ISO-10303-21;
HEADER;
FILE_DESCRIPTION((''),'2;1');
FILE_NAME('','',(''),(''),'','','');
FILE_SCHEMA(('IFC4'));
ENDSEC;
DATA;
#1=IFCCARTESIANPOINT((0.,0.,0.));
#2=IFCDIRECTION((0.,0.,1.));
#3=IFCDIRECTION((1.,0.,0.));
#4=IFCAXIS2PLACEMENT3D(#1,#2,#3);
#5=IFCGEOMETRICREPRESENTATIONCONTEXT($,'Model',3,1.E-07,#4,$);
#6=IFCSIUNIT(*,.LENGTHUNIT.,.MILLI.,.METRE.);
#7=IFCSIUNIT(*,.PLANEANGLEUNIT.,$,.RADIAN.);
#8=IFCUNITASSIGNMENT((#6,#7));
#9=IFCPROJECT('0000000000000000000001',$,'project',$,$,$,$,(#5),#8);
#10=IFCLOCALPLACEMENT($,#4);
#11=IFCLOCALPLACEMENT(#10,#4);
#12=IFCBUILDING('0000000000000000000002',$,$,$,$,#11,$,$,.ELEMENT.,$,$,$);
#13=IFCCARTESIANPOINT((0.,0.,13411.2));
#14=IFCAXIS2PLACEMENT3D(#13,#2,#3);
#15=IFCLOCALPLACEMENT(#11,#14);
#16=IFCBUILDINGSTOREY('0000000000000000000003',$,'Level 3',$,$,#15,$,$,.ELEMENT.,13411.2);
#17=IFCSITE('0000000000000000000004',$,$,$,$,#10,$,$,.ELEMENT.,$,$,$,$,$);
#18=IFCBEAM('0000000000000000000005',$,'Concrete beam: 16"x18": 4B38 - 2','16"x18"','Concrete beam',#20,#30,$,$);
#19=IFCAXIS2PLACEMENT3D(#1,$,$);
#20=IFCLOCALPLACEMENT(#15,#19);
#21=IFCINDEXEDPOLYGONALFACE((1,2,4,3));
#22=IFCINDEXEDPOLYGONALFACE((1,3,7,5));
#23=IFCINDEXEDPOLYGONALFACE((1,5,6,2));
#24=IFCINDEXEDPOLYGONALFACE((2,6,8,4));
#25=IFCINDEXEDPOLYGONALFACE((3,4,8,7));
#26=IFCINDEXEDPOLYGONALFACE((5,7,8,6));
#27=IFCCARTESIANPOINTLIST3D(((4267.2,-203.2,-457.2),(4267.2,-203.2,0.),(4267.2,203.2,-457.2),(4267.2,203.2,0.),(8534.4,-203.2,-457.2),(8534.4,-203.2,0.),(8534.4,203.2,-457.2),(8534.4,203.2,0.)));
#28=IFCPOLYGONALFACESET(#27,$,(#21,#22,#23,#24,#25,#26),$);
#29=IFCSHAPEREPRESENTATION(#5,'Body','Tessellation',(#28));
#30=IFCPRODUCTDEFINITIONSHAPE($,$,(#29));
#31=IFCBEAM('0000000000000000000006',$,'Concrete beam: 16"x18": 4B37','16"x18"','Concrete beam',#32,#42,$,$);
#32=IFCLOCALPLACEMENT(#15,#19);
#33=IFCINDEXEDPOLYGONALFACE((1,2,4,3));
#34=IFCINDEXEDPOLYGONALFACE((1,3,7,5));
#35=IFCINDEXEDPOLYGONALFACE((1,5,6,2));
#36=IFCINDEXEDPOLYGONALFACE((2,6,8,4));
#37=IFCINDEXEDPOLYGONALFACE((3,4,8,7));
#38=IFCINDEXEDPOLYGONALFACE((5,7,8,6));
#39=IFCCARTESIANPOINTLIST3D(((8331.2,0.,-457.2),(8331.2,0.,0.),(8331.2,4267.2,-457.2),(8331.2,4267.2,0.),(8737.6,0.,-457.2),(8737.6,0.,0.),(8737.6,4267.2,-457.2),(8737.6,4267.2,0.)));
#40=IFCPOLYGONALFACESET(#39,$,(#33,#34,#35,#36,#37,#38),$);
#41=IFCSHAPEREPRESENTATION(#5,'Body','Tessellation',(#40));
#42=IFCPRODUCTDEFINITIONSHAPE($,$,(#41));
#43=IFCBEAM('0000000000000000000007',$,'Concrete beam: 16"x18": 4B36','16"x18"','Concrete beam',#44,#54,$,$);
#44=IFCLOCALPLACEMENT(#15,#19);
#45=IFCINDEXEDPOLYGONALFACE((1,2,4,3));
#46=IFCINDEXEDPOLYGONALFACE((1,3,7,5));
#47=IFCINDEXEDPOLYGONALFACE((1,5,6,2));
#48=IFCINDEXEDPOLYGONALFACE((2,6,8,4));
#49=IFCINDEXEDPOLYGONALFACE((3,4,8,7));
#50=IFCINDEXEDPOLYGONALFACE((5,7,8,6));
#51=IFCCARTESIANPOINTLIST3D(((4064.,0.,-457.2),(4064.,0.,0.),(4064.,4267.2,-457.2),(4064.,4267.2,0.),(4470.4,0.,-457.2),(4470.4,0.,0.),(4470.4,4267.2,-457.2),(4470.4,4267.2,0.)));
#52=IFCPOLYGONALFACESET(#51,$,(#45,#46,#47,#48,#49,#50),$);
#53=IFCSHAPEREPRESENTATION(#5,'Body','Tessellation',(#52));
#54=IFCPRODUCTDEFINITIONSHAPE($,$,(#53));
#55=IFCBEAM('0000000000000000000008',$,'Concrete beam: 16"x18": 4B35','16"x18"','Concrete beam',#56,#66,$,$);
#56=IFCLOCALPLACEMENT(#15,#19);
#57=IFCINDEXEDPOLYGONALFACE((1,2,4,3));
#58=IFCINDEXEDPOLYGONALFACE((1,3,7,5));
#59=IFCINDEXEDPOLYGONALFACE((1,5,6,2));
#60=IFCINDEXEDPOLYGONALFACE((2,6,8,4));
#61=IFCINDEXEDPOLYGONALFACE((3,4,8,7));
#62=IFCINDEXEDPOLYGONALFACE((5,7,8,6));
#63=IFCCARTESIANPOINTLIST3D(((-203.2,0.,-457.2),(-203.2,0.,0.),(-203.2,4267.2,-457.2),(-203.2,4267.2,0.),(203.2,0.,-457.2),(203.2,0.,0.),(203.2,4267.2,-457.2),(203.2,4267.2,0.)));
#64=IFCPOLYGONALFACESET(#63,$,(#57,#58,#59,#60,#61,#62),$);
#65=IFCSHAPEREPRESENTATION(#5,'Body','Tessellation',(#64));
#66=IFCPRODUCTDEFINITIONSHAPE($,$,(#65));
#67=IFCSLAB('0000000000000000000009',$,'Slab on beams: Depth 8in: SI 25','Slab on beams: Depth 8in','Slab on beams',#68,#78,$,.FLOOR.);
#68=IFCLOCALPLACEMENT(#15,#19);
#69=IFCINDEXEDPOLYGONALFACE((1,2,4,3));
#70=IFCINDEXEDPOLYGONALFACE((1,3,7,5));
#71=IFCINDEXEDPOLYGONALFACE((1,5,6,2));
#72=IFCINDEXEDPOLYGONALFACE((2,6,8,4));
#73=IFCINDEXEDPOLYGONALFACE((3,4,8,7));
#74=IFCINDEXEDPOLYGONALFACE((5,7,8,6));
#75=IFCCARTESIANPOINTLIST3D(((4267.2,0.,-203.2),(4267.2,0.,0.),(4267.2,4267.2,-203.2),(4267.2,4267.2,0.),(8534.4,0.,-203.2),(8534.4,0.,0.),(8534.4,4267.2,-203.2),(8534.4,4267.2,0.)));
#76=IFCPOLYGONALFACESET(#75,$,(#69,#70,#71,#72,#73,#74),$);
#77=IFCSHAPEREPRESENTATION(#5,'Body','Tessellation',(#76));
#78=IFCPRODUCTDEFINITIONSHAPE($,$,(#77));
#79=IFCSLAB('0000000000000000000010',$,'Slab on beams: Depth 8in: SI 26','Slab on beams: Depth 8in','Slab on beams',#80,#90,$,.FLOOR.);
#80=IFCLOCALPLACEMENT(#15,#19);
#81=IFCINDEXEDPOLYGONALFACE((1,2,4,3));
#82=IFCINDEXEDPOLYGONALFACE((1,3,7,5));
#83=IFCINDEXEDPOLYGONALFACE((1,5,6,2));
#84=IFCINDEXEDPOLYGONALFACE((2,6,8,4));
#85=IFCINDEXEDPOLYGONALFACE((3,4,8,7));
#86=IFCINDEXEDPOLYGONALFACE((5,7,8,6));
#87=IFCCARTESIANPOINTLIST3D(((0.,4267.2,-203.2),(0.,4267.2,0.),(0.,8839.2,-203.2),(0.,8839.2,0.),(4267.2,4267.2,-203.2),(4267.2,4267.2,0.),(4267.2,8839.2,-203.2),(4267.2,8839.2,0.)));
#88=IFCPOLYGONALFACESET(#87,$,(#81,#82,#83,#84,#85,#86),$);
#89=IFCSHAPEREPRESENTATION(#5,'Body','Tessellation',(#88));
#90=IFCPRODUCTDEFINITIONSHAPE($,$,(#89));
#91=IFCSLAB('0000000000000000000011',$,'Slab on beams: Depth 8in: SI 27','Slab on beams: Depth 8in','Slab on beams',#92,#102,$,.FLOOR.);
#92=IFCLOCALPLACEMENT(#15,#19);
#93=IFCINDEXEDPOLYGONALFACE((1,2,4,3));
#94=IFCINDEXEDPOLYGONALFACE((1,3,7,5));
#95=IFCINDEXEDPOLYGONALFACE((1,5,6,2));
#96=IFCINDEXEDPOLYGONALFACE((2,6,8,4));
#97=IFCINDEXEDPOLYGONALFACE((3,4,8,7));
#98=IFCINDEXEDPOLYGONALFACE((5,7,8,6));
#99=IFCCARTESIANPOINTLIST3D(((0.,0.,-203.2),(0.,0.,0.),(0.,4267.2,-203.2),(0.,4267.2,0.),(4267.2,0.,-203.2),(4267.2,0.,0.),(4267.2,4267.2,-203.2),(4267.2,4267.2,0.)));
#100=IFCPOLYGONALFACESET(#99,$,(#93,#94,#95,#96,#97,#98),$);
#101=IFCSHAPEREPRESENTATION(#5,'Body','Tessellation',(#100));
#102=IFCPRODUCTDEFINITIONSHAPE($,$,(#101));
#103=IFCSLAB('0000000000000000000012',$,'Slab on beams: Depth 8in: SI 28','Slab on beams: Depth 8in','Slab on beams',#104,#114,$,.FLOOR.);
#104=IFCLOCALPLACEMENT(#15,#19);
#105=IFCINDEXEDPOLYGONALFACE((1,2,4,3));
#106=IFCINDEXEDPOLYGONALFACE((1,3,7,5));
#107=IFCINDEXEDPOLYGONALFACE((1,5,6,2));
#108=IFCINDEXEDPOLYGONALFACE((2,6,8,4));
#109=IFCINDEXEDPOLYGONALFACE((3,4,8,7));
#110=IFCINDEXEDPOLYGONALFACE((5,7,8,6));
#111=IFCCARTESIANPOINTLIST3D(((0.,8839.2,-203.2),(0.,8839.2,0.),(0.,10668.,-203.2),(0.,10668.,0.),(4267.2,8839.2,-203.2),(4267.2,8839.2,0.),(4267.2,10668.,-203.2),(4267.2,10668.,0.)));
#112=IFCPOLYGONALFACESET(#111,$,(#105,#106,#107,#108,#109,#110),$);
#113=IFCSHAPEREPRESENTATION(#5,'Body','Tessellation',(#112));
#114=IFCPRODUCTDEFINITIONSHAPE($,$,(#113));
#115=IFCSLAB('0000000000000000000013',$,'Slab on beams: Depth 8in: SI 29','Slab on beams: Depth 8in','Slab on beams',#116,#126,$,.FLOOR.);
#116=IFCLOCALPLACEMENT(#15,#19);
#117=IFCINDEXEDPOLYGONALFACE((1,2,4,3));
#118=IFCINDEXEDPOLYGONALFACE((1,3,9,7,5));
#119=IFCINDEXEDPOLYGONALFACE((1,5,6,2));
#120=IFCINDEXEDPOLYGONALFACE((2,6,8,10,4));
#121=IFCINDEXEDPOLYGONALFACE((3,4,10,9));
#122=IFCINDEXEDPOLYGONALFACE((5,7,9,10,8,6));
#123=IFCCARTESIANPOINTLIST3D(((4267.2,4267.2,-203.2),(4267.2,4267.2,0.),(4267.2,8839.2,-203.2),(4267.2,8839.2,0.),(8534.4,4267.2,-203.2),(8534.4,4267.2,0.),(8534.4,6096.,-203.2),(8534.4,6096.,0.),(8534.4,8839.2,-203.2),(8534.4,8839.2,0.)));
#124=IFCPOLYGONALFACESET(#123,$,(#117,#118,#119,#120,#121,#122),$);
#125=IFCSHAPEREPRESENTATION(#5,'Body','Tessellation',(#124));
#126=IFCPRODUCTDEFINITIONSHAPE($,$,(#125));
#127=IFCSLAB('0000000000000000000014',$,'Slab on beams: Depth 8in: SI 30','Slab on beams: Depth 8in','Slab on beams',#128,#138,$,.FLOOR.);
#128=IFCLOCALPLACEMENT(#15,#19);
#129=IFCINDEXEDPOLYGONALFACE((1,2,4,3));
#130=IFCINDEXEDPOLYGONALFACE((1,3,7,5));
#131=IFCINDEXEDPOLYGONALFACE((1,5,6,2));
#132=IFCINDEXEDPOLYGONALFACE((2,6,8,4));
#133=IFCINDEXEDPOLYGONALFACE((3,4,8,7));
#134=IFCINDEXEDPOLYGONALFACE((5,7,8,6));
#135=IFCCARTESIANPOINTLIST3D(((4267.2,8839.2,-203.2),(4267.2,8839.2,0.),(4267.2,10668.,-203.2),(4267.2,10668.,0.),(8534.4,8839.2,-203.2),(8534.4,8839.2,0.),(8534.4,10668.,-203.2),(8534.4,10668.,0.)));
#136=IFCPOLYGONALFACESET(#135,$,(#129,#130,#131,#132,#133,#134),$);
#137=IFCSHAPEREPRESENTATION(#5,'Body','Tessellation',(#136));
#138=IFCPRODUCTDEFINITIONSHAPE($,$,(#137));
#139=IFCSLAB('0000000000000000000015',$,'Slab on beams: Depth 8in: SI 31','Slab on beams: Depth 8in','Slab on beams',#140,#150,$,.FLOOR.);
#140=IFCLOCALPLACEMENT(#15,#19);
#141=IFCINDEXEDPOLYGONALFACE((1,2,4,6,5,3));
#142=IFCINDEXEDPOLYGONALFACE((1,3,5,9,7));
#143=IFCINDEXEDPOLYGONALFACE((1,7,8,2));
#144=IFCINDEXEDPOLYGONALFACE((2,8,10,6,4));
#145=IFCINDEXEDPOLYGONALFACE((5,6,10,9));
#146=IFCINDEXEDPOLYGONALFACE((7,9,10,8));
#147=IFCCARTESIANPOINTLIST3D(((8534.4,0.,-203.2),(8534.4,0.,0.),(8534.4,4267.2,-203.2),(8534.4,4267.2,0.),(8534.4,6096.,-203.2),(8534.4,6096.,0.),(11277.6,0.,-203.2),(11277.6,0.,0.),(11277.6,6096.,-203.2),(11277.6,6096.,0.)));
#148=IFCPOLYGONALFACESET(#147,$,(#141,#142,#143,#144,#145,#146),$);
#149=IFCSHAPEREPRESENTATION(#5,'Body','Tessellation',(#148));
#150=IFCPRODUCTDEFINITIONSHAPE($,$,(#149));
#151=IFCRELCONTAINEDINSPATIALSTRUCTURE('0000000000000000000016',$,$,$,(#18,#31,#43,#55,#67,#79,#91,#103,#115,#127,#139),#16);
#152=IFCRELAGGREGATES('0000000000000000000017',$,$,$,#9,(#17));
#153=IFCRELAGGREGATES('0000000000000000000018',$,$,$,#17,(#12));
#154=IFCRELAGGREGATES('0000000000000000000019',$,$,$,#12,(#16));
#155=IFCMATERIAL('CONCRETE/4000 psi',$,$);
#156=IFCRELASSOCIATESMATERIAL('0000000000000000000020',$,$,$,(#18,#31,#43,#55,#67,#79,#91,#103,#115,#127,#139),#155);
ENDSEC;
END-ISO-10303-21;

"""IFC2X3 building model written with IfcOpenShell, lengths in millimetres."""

from ifc_helpers import new_model, si_unit, frame, origin_with_axes, origin_2d_with_axis, place, context, project, spatial, polyline, segment, composite_curve, rectangle, outline, extrude, material, element, save


model = new_model("IFC2X3")

# Units and contexts
model_context = context("Model", 3, precision=1e-07, world=origin_with_axes())
ifc_project = project(units=[si_unit("LENGTHUNIT", "METRE", prefix="MILLI"), si_unit("PLANEANGLEUNIT", "RADIAN")], contexts=[model_context])

# Site, building, storey
site_placement = place(None, origin_with_axes())
site = spatial("IfcSite", under=ifc_project, at=site_placement, CompositionType="ELEMENT")
building_placement = place(site_placement, origin_with_axes())
building = spatial("IfcBuilding", under=site, at=building_placement, CompositionType="ELEMENT")
storey_placement = place(building_placement, frame((0.0, 0.0, 13411.2), z_axis=(0.0, 0.0, 1.0), x_axis=(1.0, 0.0, 0.0)))
storey = spatial("IfcBuildingStorey", under=building, at=storey_placement, Name="Level 3", CompositionType="ELEMENT", Elevation=13411.2)

# Beams
ifc_material = material(Name="CONCRETE/4000 psi")
for number, where, z_axis, x_axis, name in (
    (1, (4267.2, 0.0, 13411.2), (0.0, 0.0, 1.0), (1.0, 0.0, 0.0), "Concrete beam: 16\"x18\": 4B38 - 2"),
    (2, (8534.4, 0.0, 13411.2), (0.0, 0.0, 1.0), (0.0, 1.0, 0.0), "Concrete beam: 16\"x18\": 4B37"),
    (3, (4267.2, 0.0, 13411.2), (0.0, 0.0, 1.0), (0.0, 1.0, 0.0), "Concrete beam: 16\"x18\": 4B36"),
    (4, (0.0, 0.0, 13411.2), (0.0, 0.0, 1.0), (0.0, 1.0, 0.0), "Concrete beam: 16\"x18\": 4B35"),
):
    element("IfcBeam", number, at=place(building_placement, frame(where, z_axis=z_axis, x_axis=x_axis)), inside=storey, material=ifc_material, Name=name, Description="16\"x18\"", ObjectType="Concrete beam", context=model_context, shape_type="SweptSolid", body=[
        extrude(rectangle(XDim=406.4, YDim=457.2, at=origin_2d_with_axis()), frame((4267.2, 0.0, -228.6), z_axis=(-1.0, 0.0, 0.0), x_axis=(0.0, -1.0, 0.0)), (0.0, 0.0, 1.0), 4267.2),
    ])

# Slabs
slab_1_placement = place(building_placement, frame((0.0, 0.0, 13411.2), z_axis=(0.0, 0.0, 1.0), x_axis=(1.0, 0.0, 0.0)))
element("IfcSlab", 5, at=slab_1_placement, inside=storey, material=ifc_material, Name="Slab on beams: Depth 8in: SI 25", Description="Slab on beams: Depth 8in", ObjectType="Slab on beams", PredefinedType="FLOOR", context=model_context, shape_type="SweptSolid", body=[
    extrude(outline(composite_curve([segment(polyline([(4267.2, 4267.2), (4267.2, 0.0)]), True, "CONTINUOUS"), segment(polyline([(4267.2, 0.0), (8534.4, 0.0)]), True, "CONTINUOUS"), segment(polyline([(8534.4, 0.0), (8534.4, 4267.2)]), True, "CONTINUOUS"), segment(polyline([(8534.4, 4267.2), (4267.2, 4267.2)]), True, "CONTINUOUS")], self_intersect=False)), frame((0.0, 0.0, -203.2), z_axis=(0.0, 0.0, 1.0), x_axis=(1.0, 0.0, 0.0)), (0.0, 0.0, 1.0), 203.2),
])
slab_2_placement = place(building_placement, frame((0.0, 0.0, 13411.2), z_axis=(0.0, 0.0, 1.0), x_axis=(1.0, 0.0, 0.0)))
element("IfcSlab", 6, at=slab_2_placement, inside=storey, material=ifc_material, Name="Slab on beams: Depth 8in: SI 26", Description="Slab on beams: Depth 8in", ObjectType="Slab on beams", PredefinedType="FLOOR", context=model_context, shape_type="SweptSolid", body=[
    extrude(outline(composite_curve([segment(polyline([(0.0, 8839.2), (0.0, 4267.2)]), True, "CONTINUOUS"), segment(polyline([(0.0, 4267.2), (4267.2, 4267.2)]), True, "CONTINUOUS"), segment(polyline([(4267.2, 4267.2), (4267.2, 8839.2)]), True, "CONTINUOUS"), segment(polyline([(4267.2, 8839.2), (0.0, 8839.2)]), True, "CONTINUOUS")], self_intersect=False)), frame((0.0, 0.0, -203.2), z_axis=(0.0, 0.0, 1.0), x_axis=(1.0, 0.0, 0.0)), (0.0, 0.0, 1.0), 203.2),
])
slab_3_placement = place(building_placement, frame((0.0, 0.0, 13411.2), z_axis=(0.0, 0.0, 1.0), x_axis=(1.0, 0.0, 0.0)))
element("IfcSlab", 7, at=slab_3_placement, inside=storey, material=ifc_material, Name="Slab on beams: Depth 8in: SI 27", Description="Slab on beams: Depth 8in", ObjectType="Slab on beams", PredefinedType="FLOOR", context=model_context, shape_type="SweptSolid", body=[
    extrude(outline(composite_curve([segment(polyline([(0.0, 4267.2), (0.0, 0.0)]), True, "CONTINUOUS"), segment(polyline([(0.0, 0.0), (4267.2, 0.0)]), True, "CONTINUOUS"), segment(polyline([(4267.2, 0.0), (4267.2, 4267.2)]), True, "CONTINUOUS"), segment(polyline([(4267.2, 4267.2), (0.0, 4267.2)]), True, "CONTINUOUS")], self_intersect=False)), frame((0.0, 0.0, -203.2), z_axis=(0.0, 0.0, 1.0), x_axis=(1.0, 0.0, 0.0)), (0.0, 0.0, 1.0), 203.2),
])
slab_4_placement = place(building_placement, frame((0.0, 0.0, 13411.2), z_axis=(0.0, 0.0, 1.0), x_axis=(1.0, 0.0, 0.0)))
element("IfcSlab", 8, at=slab_4_placement, inside=storey, material=ifc_material, Name="Slab on beams: Depth 8in: SI 28", Description="Slab on beams: Depth 8in", ObjectType="Slab on beams", PredefinedType="FLOOR", context=model_context, shape_type="SweptSolid", body=[
    extrude(outline(composite_curve([segment(polyline([(0.0, 10668.0), (0.0, 8839.2)]), True, "CONTINUOUS"), segment(polyline([(0.0, 8839.2), (4267.2, 8839.2)]), True, "CONTINUOUS"), segment(polyline([(4267.2, 8839.2), (4267.2, 10668.0)]), True, "CONTINUOUS"), segment(polyline([(4267.2, 10668.0), (0.0, 10668.0)]), True, "CONTINUOUS")], self_intersect=False)), frame((0.0, 0.0, -203.2), z_axis=(0.0, 0.0, 1.0), x_axis=(1.0, 0.0, 0.0)), (0.0, 0.0, 1.0), 203.2),
])
slab_5_placement = place(building_placement, frame((0.0, 0.0, 13411.2), z_axis=(0.0, 0.0, 1.0), x_axis=(1.0, 0.0, 0.0)))
element("IfcSlab", 9, at=slab_5_placement, inside=storey, material=ifc_material, Name="Slab on beams: Depth 8in: SI 29", Description="Slab on beams: Depth 8in", ObjectType="Slab on beams", PredefinedType="FLOOR", context=model_context, shape_type="SweptSolid", body=[
    extrude(outline(composite_curve([segment(polyline([(4267.2, 8839.2), (4267.2, 4267.2)]), True, "CONTINUOUS"), segment(polyline([(4267.2, 4267.2), (8534.4, 4267.2)]), True, "CONTINUOUS"), segment(polyline([(8534.4, 4267.2), (8534.4, 6096.0)]), True, "CONTINUOUS"), segment(polyline([(8534.4, 6096.0), (8534.4, 8839.2)]), True, "CONTINUOUS"), segment(polyline([(8534.4, 8839.2), (4267.2, 8839.2)]), True, "CONTINUOUS")], self_intersect=False)), frame((0.0, 0.0, -203.2), z_axis=(0.0, 0.0, 1.0), x_axis=(1.0, 0.0, 0.0)), (0.0, 0.0, 1.0), 203.2),
])
slab_6_placement = place(building_placement, frame((0.0, 0.0, 13411.2), z_axis=(0.0, 0.0, 1.0), x_axis=(1.0, 0.0, 0.0)))
element("IfcSlab", 10, at=slab_6_placement, inside=storey, material=ifc_material, Name="Slab on beams: Depth 8in: SI 30", Description="Slab on beams: Depth 8in", ObjectType="Slab on beams", PredefinedType="FLOOR", context=model_context, shape_type="SweptSolid", body=[
    extrude(outline(composite_curve([segment(polyline([(4267.2, 10668.0), (4267.2, 8839.2)]), True, "CONTINUOUS"), segment(polyline([(4267.2, 8839.2), (8534.4, 8839.2)]), True, "CONTINUOUS"), segment(polyline([(8534.4, 8839.2), (8534.4, 10668.0)]), True, "CONTINUOUS"), segment(polyline([(8534.4, 10668.0), (4267.2, 10668.0)]), True, "CONTINUOUS")], self_intersect=False)), frame((0.0, 0.0, -203.2), z_axis=(0.0, 0.0, 1.0), x_axis=(1.0, 0.0, 0.0)), (0.0, 0.0, 1.0), 203.2),
])
slab_7_placement = place(building_placement, frame((0.0, 0.0, 13411.2), z_axis=(0.0, 0.0, 1.0), x_axis=(1.0, 0.0, 0.0)))
element("IfcSlab", 11, at=slab_7_placement, inside=storey, material=ifc_material, Name="Slab on beams: Depth 8in: SI 31", Description="Slab on beams: Depth 8in", ObjectType="Slab on beams", PredefinedType="FLOOR", context=model_context, shape_type="SweptSolid", body=[
    extrude(outline(composite_curve([segment(polyline([(8534.4, 6096.0), (8534.4, 4267.2)]), True, "CONTINUOUS"), segment(polyline([(8534.4, 4267.2), (8534.4, 0.0)]), True, "CONTINUOUS"), segment(polyline([(8534.4, 0.0), (11277.6, 0.0)]), True, "CONTINUOUS"), segment(polyline([(11277.6, 0.0), (11277.6, 6096.0)]), True, "CONTINUOUS"), segment(polyline([(11277.6, 6096.0), (8534.4, 6096.0)]), True, "CONTINUOUS")], self_intersect=False)), frame((0.0, 0.0, -203.2), z_axis=(0.0, 0.0, 1.0), x_axis=(1.0, 0.0, 0.0)), (0.0, 0.0, 1.0), 203.2),
])

save(model, "model.ifc")
